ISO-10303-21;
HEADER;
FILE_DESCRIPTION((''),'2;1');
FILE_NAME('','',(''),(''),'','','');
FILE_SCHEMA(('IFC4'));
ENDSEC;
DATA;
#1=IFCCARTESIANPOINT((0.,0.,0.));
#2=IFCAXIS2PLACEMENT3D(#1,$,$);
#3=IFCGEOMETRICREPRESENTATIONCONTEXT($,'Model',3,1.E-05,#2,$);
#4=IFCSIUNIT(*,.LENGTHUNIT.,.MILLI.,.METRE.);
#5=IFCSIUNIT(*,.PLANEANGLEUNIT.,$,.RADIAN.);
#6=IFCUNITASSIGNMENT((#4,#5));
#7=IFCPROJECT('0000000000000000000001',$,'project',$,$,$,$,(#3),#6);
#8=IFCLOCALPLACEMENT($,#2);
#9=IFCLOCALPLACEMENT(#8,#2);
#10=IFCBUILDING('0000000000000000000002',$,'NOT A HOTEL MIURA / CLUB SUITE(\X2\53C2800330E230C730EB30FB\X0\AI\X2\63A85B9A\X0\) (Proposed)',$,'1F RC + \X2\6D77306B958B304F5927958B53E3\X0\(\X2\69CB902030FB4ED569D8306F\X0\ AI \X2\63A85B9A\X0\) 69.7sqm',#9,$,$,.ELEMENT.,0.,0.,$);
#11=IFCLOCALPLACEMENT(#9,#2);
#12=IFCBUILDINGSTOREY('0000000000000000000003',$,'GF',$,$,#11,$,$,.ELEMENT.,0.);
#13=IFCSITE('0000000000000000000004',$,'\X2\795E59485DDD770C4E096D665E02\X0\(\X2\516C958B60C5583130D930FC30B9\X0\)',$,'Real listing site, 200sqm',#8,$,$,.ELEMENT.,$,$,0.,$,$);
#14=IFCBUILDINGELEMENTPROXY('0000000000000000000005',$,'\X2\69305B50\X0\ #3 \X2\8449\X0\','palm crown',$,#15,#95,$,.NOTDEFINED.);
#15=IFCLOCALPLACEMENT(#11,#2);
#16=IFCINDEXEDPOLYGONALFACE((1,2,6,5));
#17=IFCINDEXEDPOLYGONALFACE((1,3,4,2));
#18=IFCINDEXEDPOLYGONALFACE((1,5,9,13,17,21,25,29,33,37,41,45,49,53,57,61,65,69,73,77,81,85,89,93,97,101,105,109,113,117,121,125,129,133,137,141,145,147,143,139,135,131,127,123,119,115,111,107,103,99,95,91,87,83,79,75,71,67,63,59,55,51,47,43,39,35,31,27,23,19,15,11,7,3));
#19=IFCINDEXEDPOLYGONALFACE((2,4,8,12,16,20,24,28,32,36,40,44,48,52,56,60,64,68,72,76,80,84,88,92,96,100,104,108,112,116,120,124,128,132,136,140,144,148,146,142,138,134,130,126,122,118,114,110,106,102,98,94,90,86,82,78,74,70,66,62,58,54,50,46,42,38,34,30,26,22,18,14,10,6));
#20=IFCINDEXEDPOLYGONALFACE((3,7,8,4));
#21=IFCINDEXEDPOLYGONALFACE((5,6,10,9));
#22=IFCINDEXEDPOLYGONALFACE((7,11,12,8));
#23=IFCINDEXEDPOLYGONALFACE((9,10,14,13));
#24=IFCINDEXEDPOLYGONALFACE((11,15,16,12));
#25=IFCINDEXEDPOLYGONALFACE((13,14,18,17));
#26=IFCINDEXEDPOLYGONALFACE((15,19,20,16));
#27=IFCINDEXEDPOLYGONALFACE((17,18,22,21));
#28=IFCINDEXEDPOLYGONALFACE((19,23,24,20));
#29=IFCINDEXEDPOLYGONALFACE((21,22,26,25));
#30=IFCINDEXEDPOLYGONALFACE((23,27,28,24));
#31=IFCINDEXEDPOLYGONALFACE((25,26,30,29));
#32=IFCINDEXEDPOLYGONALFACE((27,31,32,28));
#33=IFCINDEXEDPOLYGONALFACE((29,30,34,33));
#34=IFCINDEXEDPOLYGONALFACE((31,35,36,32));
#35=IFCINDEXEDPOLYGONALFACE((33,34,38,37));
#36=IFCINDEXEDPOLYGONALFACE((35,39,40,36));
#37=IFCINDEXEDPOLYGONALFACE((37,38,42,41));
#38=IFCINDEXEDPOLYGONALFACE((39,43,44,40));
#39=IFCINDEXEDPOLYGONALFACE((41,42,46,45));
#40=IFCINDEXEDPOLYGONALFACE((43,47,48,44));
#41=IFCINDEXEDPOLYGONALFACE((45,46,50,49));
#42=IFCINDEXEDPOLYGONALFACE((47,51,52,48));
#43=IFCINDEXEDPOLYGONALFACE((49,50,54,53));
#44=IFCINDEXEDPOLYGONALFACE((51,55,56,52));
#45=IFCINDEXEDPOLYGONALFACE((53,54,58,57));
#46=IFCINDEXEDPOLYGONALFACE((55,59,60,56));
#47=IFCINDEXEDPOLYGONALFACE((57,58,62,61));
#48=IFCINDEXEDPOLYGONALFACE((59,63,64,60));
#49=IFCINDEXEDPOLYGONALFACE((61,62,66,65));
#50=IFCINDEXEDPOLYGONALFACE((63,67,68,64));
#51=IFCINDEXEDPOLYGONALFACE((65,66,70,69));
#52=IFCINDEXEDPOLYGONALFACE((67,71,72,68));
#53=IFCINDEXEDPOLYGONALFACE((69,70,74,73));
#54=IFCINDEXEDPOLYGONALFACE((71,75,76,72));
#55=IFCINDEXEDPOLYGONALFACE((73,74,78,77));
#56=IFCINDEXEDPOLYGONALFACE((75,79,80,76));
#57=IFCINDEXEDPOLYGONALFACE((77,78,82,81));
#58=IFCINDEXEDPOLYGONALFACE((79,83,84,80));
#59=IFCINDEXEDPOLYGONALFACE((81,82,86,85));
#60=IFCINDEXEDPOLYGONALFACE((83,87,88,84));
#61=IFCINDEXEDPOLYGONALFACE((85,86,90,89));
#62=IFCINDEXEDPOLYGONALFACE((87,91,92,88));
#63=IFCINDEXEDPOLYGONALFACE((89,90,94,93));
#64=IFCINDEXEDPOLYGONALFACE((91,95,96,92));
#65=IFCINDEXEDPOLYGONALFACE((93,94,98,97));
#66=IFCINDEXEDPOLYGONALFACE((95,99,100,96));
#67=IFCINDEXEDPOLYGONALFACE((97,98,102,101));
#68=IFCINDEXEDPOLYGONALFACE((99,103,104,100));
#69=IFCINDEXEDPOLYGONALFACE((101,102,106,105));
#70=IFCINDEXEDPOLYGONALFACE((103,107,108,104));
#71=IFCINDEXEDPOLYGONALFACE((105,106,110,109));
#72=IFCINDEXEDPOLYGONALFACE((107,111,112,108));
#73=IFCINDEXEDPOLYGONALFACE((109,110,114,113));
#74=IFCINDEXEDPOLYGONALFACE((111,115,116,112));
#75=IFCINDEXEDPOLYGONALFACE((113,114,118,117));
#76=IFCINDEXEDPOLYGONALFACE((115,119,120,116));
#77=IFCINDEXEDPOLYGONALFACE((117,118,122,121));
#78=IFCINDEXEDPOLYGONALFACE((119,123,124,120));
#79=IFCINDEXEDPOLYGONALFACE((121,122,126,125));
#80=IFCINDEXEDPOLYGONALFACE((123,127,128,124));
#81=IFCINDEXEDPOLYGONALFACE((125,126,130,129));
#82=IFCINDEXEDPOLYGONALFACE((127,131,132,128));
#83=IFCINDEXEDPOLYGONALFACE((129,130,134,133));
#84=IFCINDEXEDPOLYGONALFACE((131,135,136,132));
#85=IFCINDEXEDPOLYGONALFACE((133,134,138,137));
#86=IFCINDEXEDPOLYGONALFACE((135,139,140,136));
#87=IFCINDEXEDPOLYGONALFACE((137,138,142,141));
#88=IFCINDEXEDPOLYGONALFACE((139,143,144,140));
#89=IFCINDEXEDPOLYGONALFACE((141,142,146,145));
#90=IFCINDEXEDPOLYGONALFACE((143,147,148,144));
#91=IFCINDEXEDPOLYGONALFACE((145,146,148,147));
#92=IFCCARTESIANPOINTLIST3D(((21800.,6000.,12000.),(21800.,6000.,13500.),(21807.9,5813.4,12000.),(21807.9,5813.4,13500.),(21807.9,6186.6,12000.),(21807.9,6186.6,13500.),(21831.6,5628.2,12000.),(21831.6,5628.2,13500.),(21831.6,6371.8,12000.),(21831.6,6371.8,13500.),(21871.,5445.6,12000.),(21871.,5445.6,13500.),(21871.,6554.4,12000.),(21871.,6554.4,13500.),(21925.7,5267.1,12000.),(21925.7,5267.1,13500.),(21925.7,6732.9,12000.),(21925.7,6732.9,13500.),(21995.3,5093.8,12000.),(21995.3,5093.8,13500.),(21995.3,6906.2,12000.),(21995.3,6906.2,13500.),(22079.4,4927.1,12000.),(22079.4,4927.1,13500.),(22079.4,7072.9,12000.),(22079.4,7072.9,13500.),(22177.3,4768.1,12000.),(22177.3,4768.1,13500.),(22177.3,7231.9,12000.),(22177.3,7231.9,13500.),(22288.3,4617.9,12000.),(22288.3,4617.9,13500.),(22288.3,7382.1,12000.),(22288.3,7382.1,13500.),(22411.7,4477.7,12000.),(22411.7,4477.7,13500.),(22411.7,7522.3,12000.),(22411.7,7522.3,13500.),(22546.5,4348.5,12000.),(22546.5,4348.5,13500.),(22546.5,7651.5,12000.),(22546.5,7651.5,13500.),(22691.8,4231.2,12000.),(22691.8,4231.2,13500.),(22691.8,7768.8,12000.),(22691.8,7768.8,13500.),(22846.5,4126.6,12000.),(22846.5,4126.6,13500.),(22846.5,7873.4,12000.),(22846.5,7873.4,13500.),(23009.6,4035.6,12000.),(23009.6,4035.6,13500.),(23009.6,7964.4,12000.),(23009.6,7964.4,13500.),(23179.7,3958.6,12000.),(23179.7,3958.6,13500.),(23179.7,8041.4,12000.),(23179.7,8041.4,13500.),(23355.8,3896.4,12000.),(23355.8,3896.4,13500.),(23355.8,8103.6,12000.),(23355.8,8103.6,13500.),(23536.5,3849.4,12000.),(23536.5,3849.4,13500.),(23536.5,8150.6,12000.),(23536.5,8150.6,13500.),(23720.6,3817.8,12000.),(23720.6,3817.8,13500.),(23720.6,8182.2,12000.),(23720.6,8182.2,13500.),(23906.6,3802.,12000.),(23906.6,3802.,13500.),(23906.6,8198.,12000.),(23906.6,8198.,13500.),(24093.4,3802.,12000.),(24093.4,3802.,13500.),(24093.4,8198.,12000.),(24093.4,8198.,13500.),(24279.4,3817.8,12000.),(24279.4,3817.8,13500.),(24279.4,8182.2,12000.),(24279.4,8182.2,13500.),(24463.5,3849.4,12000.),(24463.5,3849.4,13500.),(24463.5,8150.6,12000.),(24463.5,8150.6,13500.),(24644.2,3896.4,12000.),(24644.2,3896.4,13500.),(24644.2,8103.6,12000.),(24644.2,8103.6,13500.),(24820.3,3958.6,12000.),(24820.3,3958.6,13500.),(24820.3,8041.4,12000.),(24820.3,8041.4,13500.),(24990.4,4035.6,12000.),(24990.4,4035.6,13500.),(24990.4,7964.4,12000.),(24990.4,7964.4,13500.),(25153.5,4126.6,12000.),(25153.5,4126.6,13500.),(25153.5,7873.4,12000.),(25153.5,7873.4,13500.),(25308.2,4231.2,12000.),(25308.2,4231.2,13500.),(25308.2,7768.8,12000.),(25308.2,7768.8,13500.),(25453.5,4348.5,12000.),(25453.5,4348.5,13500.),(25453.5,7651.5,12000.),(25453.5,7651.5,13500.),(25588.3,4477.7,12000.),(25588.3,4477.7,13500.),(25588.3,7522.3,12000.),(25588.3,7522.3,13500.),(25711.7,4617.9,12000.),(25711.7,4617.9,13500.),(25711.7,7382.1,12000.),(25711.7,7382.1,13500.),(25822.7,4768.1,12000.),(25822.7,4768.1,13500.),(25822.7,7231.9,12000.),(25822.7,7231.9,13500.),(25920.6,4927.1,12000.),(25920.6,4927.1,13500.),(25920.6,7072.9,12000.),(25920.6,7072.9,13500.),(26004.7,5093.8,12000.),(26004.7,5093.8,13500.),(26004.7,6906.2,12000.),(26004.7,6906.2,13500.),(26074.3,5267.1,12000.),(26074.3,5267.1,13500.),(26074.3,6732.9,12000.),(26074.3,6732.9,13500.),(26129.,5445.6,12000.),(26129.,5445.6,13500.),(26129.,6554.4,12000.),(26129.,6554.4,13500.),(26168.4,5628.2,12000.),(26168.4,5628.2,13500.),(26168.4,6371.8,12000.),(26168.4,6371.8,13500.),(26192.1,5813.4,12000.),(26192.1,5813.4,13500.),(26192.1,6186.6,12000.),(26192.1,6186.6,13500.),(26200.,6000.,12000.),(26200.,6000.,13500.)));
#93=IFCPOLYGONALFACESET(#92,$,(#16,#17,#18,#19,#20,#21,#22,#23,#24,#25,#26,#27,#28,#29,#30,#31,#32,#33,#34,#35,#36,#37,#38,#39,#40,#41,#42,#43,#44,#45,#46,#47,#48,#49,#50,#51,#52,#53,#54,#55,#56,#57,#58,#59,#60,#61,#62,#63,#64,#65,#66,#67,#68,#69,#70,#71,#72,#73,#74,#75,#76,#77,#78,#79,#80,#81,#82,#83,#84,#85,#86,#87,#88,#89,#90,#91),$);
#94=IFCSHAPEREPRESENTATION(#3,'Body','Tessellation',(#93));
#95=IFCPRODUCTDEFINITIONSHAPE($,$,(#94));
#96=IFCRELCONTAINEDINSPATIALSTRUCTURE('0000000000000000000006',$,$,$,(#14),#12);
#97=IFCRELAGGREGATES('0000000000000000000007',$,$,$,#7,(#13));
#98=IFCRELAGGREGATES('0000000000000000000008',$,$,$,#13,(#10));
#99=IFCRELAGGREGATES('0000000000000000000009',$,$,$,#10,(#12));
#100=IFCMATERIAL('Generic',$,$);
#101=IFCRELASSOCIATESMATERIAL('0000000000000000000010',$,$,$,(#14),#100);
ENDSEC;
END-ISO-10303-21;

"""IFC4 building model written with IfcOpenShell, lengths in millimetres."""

from ifc_helpers import new_model, si_unit, frame, origin, origin_2d, place, context, project, spatial, circle, extrude, material, element, save


model = new_model("IFC4")

# Units and contexts
model_context = context("Model", 3, precision=1e-05, world=origin())
ifc_project = project(units=[si_unit("LENGTHUNIT", "METRE", prefix="MILLI"), si_unit("PLANEANGLEUNIT", "RADIAN")], contexts=[model_context])

# Site, building, storey
site_placement = place(None, origin())
site = spatial("IfcSite", under=ifc_project, at=site_placement, Name="神奈川県三浦市(公開情報ベース)", ObjectType="Real listing site, 200sqm", CompositionType="ELEMENT", RefElevation=0.0)
building_placement = place(site_placement, origin())
building = spatial("IfcBuilding", under=site, at=building_placement, Name="NOT A HOTEL MIURA / CLUB SUITE(参考モデル・AI推定) (Proposed)", ObjectType="1F RC + 海に開く大開口(構造・仕様は AI 推定) 69.7sqm", CompositionType="ELEMENT", ElevationOfRefHeight=0.0, ElevationOfTerrain=0.0)
storey_placement = place(building_placement, origin())
storey = spatial("IfcBuildingStorey", under=building, at=storey_placement, Name="GF", CompositionType="ELEMENT", Elevation=0.0)

# Shared definitions
ifc_material_1 = material(Name="Generic")

# Building element proxy
proxy_1_placement = place(storey_placement, frame((12000.0, 3000.0, 6000.0)))
element("IfcBuildingElementProxy", 1, at=proxy_1_placement, inside=storey, material=ifc_material_1, Name="椰子 #3 葉", Description="palm crown", PredefinedType="NOTDEFINED", context=model_context, shape_type="SweptSolid", body=[
    extrude(circle(Radius=2200.0, at=origin_2d()), frame((12000.0, 3000.0, 6000.0)), (0.0, 0.0, 1.0), 1500.0),
])

save(model, "model.ifc")
